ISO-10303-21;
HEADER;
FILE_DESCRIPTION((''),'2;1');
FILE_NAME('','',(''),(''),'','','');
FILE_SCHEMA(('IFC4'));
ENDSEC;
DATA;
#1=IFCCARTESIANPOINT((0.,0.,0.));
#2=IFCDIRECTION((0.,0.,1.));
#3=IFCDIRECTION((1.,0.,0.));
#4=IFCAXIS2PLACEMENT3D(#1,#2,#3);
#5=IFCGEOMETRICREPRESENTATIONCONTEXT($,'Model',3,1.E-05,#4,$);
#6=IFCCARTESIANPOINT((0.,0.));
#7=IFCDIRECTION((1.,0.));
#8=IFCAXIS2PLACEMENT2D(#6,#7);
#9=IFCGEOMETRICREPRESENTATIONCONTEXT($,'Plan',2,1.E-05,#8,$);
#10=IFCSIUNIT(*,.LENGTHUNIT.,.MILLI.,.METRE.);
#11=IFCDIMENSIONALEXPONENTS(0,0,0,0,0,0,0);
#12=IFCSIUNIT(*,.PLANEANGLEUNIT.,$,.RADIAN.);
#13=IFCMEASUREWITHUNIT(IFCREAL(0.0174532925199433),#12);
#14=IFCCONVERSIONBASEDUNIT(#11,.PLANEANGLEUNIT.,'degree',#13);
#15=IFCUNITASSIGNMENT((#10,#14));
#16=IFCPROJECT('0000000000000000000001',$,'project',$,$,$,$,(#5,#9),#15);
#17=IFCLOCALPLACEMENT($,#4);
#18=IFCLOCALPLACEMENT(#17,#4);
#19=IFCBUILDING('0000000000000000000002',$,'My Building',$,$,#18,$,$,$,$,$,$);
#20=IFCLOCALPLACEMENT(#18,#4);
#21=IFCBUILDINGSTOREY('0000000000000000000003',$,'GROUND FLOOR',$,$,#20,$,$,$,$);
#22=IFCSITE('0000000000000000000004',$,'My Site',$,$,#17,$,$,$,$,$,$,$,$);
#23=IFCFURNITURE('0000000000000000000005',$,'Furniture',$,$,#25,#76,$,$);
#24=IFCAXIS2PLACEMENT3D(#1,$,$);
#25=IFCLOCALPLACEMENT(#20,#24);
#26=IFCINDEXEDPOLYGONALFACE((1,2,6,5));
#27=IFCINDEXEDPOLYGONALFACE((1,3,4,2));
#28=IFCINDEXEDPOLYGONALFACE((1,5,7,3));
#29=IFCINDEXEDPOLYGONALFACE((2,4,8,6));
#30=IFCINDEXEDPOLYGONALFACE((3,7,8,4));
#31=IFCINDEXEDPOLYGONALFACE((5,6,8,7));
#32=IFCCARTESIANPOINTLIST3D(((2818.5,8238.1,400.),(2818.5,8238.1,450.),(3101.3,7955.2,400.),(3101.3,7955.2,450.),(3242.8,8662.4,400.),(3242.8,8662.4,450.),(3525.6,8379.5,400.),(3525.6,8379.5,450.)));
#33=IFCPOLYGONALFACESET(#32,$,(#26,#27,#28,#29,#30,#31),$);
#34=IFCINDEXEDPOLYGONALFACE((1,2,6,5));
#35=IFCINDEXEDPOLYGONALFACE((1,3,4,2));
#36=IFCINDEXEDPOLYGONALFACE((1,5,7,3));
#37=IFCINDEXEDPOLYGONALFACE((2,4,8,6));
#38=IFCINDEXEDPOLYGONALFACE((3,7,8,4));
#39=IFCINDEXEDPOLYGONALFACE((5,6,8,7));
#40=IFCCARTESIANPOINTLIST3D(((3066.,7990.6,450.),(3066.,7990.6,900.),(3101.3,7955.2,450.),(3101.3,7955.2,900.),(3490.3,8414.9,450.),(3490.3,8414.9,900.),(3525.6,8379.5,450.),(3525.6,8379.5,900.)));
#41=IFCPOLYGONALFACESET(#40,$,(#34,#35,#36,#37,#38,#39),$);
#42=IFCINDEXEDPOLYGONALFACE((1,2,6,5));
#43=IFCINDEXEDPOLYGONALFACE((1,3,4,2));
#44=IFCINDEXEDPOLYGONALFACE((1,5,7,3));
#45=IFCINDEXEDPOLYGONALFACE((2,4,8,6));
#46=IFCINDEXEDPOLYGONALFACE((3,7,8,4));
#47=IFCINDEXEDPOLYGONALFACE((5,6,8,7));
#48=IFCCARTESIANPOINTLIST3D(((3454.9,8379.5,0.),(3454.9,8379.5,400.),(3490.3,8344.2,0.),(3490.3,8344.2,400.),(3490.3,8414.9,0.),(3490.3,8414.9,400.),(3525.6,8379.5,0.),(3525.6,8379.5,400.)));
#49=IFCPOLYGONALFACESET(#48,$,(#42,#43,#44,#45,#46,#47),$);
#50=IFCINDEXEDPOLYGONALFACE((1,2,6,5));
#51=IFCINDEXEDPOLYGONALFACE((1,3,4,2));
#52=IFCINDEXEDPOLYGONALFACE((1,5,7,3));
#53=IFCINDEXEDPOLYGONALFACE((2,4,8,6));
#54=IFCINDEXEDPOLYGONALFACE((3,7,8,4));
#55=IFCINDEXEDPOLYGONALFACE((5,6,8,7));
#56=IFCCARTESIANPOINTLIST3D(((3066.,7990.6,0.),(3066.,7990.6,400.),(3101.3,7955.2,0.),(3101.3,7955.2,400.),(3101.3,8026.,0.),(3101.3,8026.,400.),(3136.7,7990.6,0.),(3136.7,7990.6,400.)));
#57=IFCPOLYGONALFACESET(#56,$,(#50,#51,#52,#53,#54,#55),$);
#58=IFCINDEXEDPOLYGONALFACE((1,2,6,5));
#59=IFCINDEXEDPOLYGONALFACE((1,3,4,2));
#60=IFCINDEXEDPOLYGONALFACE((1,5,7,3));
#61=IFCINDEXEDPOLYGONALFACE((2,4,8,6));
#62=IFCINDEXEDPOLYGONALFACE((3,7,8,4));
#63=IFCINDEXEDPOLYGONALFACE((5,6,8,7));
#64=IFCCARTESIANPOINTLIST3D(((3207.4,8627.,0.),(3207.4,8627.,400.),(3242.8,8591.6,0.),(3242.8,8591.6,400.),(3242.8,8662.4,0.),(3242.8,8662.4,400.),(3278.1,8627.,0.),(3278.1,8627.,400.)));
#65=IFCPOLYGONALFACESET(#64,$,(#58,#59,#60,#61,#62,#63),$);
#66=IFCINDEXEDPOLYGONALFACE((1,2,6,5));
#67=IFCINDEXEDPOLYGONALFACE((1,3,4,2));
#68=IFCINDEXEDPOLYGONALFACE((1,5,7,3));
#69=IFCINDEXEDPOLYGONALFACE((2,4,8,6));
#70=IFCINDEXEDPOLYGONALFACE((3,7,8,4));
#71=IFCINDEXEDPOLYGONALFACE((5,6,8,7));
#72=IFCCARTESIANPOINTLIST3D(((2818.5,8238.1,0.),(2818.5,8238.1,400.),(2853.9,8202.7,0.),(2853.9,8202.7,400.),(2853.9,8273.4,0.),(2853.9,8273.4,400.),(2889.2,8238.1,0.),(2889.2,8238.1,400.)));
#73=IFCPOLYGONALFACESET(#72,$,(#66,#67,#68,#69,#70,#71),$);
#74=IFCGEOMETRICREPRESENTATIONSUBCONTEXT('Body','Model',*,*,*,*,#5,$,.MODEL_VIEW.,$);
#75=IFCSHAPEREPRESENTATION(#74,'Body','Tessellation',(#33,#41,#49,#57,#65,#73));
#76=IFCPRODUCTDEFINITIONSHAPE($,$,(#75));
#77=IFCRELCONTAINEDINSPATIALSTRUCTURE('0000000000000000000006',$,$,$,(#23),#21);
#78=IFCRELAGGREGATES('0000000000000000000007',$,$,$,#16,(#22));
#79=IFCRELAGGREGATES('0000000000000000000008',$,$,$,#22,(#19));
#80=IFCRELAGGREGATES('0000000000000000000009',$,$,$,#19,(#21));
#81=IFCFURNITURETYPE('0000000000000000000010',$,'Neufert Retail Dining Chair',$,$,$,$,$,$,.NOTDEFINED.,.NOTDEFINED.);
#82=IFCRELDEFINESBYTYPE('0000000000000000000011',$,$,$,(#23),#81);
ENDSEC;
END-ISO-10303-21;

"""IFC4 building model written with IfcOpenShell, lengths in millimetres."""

from ifc_helpers import new_model, entity, si_unit, converted_unit, frame, origin_with_axes, origin_2d_with_axis, place, context, subcontext, project, spatial, line, indexed_curve, outline, extrude, shape, source, transform, mapped, type_object, type_shapes, element, save


model = new_model("IFC4")

# Units and contexts
model_context = context("Model", 3, precision=1e-05, world=origin_with_axes())
plan_context = context("Plan", 2, precision=1e-05, world=origin_2d_with_axis())
body_context_1 = subcontext(model_context, "Body", "Model", "MODEL_VIEW")
body_context_2 = subcontext(plan_context, "Body", "Plan", "PLAN_VIEW")
ifc_project = project(units=[si_unit("LENGTHUNIT", "METRE", prefix="MILLI"), converted_unit("PLANEANGLEUNIT", "degree", entity("IfcReal", 0.0174532925199433), si_unit("PLANEANGLEUNIT", "RADIAN"), dimensions=[0, 0, 0, 0, 0, 0, 0])], contexts=[model_context, plan_context])

# Site, building, storey
site_placement = place(None, origin_with_axes())
site = spatial("IfcSite", under=ifc_project, at=site_placement, Name="My Site")
building_placement = place(site_placement, origin_with_axes())
building = spatial("IfcBuilding", under=site, at=building_placement, Name="My Building")
storey_placement = place(building_placement, origin_with_axes())
storey = spatial("IfcBuildingStorey", under=building, at=storey_placement, Name="GROUND FLOOR")

# Furniture
furniture_type_1 = type_object("IfcFurnitureType", Name="Neufert Retail Dining Chair", AssemblyPlace="NOTDEFINED", PredefinedType="NOTDEFINED")
shared_shape_1 = source(origin_with_axes(), body_context_1, "Body", "SweptSolid", [
    extrude(outline(indexed_curve([(-300.0, 0.0), (300.0, 0.0), (300.0, -400.0), (-300.0, -400.0)], segments=[line(1, 2), line(2, 3), line(3, 4), line(4, 1)])), frame((0.0, 0.0, 450.0), z_axis=(0.0, 0.0, 1.0), x_axis=(1.0, 0.0, 0.0)), (0.0, 0.0, -1.0), 50.0),
    extrude(outline(indexed_curve([(-300.0, 0.0), (300.0, 0.0), (300.0, -50.0), (-300.0, -50.0)], segments=[line(1, 2), line(2, 3), line(3, 4), line(4, 1)])), frame((0.0, 0.0, 900.0), z_axis=(0.0, 0.0, 1.0), x_axis=(1.0, 0.0, 0.0)), (0.0, 0.0, -1.0), 450.0),
    extrude(outline(indexed_curve([(-300.0, 0.0), (-250.0, 0.0), (-250.0, -50.0), (-300.0, -50.0)], segments=[line(1, 2), line(2, 3), line(3, 4), line(4, 1)])), origin_with_axes(), (0.0, 0.0, 1.0), 400.0),
    extrude(outline(indexed_curve([(300.0, 0.0), (250.0, 0.0), (250.0, -50.0), (300.0, -50.0)], segments=[line(1, 2), line(2, 3), line(3, 4), line(4, 1)])), origin_with_axes(), (0.0, 0.0, 1.0), 400.0),
    extrude(outline(indexed_curve([(-300.0, -400.0), (-250.0, -400.0), (-250.0, -350.0), (-300.0, -350.0)], segments=[line(1, 2), line(2, 3), line(3, 4), line(4, 1)])), origin_with_axes(), (0.0, 0.0, 1.0), 400.0),
    extrude(outline(indexed_curve([(300.0, -400.0), (250.0, -400.0), (250.0, -350.0), (300.0, -350.0)], segments=[line(1, 2), line(2, 3), line(3, 4), line(4, 1)])), origin_with_axes(), (0.0, 0.0, 1.0), 400.0),
])
shared_shape_2 = source(origin_with_axes(), body_context_2, "Body", "Curve2D", [
    entity("IfcIndexedPolyCurve", entity("IfcCartesianPointList2D", [[-300.0, -400.0], [300.0, -400.0]]), [entity("IfcLineIndex", [1, 2])]),
    entity("IfcIndexedPolyCurve", entity("IfcCartesianPointList2D", [[-300.0, -400.0], [-300.0, -300.0], [-212.1, -87.9], [0.0, 0.0], [212.1, -87.9], [300.0, -300.0], [300.0, -400.0]]), [entity("IfcLineIndex", [1, 2]), entity("IfcArcIndex", [2, 3, 4]), entity("IfcArcIndex", [4, 5, 6]), entity("IfcLineIndex", [6, 7])]),
    entity("IfcIndexedPolyCurve", entity("IfcCartesianPointList2D", [[-260.0, -400.0], [-260.0, -300.0], [-183.8, -116.2], [0.0, -40.0], [183.8, -116.2], [260.0, -300.0], [260.0, -400.0]]), [entity("IfcLineIndex", [1, 2]), entity("IfcArcIndex", [2, 3, 4]), entity("IfcArcIndex", [4, 5, 6]), entity("IfcLineIndex", [6, 7])]),
])
type_shapes(furniture_type_1, [shared_shape_1, shared_shape_2])
furniture_1_placement = place(storey_placement, frame((3313.5, 8167.4, 0.0), z_axis=(0.0, 0.0, 1.0), x_axis=(-0.707107, -0.707107, 0.0)))
element("IfcFurniture", 1, at=furniture_1_placement, inside=storey, type_object=furniture_type_1, Name="Furniture", shapes=[
    shape(body_context_1, "Body", "MappedRepresentation", [mapped(shared_shape_1, transform((0.0, 0.0, 0.0), x_axis=(1.0, 0.0, 0.0), y_axis=(0.0, 1.0, 0.0), z_axis=(0.0, 0.0, 1.0), scale=1.0))]),
    shape(body_context_2, "Body", "MappedRepresentation", [mapped(shared_shape_2, transform((0.0, 0.0, 0.0), x_axis=(1.0, 0.0, 0.0), y_axis=(0.0, 1.0, 0.0), z_axis=(0.0, 0.0, 1.0), scale=1.0))]),
])

save(model, "model.ifc")
